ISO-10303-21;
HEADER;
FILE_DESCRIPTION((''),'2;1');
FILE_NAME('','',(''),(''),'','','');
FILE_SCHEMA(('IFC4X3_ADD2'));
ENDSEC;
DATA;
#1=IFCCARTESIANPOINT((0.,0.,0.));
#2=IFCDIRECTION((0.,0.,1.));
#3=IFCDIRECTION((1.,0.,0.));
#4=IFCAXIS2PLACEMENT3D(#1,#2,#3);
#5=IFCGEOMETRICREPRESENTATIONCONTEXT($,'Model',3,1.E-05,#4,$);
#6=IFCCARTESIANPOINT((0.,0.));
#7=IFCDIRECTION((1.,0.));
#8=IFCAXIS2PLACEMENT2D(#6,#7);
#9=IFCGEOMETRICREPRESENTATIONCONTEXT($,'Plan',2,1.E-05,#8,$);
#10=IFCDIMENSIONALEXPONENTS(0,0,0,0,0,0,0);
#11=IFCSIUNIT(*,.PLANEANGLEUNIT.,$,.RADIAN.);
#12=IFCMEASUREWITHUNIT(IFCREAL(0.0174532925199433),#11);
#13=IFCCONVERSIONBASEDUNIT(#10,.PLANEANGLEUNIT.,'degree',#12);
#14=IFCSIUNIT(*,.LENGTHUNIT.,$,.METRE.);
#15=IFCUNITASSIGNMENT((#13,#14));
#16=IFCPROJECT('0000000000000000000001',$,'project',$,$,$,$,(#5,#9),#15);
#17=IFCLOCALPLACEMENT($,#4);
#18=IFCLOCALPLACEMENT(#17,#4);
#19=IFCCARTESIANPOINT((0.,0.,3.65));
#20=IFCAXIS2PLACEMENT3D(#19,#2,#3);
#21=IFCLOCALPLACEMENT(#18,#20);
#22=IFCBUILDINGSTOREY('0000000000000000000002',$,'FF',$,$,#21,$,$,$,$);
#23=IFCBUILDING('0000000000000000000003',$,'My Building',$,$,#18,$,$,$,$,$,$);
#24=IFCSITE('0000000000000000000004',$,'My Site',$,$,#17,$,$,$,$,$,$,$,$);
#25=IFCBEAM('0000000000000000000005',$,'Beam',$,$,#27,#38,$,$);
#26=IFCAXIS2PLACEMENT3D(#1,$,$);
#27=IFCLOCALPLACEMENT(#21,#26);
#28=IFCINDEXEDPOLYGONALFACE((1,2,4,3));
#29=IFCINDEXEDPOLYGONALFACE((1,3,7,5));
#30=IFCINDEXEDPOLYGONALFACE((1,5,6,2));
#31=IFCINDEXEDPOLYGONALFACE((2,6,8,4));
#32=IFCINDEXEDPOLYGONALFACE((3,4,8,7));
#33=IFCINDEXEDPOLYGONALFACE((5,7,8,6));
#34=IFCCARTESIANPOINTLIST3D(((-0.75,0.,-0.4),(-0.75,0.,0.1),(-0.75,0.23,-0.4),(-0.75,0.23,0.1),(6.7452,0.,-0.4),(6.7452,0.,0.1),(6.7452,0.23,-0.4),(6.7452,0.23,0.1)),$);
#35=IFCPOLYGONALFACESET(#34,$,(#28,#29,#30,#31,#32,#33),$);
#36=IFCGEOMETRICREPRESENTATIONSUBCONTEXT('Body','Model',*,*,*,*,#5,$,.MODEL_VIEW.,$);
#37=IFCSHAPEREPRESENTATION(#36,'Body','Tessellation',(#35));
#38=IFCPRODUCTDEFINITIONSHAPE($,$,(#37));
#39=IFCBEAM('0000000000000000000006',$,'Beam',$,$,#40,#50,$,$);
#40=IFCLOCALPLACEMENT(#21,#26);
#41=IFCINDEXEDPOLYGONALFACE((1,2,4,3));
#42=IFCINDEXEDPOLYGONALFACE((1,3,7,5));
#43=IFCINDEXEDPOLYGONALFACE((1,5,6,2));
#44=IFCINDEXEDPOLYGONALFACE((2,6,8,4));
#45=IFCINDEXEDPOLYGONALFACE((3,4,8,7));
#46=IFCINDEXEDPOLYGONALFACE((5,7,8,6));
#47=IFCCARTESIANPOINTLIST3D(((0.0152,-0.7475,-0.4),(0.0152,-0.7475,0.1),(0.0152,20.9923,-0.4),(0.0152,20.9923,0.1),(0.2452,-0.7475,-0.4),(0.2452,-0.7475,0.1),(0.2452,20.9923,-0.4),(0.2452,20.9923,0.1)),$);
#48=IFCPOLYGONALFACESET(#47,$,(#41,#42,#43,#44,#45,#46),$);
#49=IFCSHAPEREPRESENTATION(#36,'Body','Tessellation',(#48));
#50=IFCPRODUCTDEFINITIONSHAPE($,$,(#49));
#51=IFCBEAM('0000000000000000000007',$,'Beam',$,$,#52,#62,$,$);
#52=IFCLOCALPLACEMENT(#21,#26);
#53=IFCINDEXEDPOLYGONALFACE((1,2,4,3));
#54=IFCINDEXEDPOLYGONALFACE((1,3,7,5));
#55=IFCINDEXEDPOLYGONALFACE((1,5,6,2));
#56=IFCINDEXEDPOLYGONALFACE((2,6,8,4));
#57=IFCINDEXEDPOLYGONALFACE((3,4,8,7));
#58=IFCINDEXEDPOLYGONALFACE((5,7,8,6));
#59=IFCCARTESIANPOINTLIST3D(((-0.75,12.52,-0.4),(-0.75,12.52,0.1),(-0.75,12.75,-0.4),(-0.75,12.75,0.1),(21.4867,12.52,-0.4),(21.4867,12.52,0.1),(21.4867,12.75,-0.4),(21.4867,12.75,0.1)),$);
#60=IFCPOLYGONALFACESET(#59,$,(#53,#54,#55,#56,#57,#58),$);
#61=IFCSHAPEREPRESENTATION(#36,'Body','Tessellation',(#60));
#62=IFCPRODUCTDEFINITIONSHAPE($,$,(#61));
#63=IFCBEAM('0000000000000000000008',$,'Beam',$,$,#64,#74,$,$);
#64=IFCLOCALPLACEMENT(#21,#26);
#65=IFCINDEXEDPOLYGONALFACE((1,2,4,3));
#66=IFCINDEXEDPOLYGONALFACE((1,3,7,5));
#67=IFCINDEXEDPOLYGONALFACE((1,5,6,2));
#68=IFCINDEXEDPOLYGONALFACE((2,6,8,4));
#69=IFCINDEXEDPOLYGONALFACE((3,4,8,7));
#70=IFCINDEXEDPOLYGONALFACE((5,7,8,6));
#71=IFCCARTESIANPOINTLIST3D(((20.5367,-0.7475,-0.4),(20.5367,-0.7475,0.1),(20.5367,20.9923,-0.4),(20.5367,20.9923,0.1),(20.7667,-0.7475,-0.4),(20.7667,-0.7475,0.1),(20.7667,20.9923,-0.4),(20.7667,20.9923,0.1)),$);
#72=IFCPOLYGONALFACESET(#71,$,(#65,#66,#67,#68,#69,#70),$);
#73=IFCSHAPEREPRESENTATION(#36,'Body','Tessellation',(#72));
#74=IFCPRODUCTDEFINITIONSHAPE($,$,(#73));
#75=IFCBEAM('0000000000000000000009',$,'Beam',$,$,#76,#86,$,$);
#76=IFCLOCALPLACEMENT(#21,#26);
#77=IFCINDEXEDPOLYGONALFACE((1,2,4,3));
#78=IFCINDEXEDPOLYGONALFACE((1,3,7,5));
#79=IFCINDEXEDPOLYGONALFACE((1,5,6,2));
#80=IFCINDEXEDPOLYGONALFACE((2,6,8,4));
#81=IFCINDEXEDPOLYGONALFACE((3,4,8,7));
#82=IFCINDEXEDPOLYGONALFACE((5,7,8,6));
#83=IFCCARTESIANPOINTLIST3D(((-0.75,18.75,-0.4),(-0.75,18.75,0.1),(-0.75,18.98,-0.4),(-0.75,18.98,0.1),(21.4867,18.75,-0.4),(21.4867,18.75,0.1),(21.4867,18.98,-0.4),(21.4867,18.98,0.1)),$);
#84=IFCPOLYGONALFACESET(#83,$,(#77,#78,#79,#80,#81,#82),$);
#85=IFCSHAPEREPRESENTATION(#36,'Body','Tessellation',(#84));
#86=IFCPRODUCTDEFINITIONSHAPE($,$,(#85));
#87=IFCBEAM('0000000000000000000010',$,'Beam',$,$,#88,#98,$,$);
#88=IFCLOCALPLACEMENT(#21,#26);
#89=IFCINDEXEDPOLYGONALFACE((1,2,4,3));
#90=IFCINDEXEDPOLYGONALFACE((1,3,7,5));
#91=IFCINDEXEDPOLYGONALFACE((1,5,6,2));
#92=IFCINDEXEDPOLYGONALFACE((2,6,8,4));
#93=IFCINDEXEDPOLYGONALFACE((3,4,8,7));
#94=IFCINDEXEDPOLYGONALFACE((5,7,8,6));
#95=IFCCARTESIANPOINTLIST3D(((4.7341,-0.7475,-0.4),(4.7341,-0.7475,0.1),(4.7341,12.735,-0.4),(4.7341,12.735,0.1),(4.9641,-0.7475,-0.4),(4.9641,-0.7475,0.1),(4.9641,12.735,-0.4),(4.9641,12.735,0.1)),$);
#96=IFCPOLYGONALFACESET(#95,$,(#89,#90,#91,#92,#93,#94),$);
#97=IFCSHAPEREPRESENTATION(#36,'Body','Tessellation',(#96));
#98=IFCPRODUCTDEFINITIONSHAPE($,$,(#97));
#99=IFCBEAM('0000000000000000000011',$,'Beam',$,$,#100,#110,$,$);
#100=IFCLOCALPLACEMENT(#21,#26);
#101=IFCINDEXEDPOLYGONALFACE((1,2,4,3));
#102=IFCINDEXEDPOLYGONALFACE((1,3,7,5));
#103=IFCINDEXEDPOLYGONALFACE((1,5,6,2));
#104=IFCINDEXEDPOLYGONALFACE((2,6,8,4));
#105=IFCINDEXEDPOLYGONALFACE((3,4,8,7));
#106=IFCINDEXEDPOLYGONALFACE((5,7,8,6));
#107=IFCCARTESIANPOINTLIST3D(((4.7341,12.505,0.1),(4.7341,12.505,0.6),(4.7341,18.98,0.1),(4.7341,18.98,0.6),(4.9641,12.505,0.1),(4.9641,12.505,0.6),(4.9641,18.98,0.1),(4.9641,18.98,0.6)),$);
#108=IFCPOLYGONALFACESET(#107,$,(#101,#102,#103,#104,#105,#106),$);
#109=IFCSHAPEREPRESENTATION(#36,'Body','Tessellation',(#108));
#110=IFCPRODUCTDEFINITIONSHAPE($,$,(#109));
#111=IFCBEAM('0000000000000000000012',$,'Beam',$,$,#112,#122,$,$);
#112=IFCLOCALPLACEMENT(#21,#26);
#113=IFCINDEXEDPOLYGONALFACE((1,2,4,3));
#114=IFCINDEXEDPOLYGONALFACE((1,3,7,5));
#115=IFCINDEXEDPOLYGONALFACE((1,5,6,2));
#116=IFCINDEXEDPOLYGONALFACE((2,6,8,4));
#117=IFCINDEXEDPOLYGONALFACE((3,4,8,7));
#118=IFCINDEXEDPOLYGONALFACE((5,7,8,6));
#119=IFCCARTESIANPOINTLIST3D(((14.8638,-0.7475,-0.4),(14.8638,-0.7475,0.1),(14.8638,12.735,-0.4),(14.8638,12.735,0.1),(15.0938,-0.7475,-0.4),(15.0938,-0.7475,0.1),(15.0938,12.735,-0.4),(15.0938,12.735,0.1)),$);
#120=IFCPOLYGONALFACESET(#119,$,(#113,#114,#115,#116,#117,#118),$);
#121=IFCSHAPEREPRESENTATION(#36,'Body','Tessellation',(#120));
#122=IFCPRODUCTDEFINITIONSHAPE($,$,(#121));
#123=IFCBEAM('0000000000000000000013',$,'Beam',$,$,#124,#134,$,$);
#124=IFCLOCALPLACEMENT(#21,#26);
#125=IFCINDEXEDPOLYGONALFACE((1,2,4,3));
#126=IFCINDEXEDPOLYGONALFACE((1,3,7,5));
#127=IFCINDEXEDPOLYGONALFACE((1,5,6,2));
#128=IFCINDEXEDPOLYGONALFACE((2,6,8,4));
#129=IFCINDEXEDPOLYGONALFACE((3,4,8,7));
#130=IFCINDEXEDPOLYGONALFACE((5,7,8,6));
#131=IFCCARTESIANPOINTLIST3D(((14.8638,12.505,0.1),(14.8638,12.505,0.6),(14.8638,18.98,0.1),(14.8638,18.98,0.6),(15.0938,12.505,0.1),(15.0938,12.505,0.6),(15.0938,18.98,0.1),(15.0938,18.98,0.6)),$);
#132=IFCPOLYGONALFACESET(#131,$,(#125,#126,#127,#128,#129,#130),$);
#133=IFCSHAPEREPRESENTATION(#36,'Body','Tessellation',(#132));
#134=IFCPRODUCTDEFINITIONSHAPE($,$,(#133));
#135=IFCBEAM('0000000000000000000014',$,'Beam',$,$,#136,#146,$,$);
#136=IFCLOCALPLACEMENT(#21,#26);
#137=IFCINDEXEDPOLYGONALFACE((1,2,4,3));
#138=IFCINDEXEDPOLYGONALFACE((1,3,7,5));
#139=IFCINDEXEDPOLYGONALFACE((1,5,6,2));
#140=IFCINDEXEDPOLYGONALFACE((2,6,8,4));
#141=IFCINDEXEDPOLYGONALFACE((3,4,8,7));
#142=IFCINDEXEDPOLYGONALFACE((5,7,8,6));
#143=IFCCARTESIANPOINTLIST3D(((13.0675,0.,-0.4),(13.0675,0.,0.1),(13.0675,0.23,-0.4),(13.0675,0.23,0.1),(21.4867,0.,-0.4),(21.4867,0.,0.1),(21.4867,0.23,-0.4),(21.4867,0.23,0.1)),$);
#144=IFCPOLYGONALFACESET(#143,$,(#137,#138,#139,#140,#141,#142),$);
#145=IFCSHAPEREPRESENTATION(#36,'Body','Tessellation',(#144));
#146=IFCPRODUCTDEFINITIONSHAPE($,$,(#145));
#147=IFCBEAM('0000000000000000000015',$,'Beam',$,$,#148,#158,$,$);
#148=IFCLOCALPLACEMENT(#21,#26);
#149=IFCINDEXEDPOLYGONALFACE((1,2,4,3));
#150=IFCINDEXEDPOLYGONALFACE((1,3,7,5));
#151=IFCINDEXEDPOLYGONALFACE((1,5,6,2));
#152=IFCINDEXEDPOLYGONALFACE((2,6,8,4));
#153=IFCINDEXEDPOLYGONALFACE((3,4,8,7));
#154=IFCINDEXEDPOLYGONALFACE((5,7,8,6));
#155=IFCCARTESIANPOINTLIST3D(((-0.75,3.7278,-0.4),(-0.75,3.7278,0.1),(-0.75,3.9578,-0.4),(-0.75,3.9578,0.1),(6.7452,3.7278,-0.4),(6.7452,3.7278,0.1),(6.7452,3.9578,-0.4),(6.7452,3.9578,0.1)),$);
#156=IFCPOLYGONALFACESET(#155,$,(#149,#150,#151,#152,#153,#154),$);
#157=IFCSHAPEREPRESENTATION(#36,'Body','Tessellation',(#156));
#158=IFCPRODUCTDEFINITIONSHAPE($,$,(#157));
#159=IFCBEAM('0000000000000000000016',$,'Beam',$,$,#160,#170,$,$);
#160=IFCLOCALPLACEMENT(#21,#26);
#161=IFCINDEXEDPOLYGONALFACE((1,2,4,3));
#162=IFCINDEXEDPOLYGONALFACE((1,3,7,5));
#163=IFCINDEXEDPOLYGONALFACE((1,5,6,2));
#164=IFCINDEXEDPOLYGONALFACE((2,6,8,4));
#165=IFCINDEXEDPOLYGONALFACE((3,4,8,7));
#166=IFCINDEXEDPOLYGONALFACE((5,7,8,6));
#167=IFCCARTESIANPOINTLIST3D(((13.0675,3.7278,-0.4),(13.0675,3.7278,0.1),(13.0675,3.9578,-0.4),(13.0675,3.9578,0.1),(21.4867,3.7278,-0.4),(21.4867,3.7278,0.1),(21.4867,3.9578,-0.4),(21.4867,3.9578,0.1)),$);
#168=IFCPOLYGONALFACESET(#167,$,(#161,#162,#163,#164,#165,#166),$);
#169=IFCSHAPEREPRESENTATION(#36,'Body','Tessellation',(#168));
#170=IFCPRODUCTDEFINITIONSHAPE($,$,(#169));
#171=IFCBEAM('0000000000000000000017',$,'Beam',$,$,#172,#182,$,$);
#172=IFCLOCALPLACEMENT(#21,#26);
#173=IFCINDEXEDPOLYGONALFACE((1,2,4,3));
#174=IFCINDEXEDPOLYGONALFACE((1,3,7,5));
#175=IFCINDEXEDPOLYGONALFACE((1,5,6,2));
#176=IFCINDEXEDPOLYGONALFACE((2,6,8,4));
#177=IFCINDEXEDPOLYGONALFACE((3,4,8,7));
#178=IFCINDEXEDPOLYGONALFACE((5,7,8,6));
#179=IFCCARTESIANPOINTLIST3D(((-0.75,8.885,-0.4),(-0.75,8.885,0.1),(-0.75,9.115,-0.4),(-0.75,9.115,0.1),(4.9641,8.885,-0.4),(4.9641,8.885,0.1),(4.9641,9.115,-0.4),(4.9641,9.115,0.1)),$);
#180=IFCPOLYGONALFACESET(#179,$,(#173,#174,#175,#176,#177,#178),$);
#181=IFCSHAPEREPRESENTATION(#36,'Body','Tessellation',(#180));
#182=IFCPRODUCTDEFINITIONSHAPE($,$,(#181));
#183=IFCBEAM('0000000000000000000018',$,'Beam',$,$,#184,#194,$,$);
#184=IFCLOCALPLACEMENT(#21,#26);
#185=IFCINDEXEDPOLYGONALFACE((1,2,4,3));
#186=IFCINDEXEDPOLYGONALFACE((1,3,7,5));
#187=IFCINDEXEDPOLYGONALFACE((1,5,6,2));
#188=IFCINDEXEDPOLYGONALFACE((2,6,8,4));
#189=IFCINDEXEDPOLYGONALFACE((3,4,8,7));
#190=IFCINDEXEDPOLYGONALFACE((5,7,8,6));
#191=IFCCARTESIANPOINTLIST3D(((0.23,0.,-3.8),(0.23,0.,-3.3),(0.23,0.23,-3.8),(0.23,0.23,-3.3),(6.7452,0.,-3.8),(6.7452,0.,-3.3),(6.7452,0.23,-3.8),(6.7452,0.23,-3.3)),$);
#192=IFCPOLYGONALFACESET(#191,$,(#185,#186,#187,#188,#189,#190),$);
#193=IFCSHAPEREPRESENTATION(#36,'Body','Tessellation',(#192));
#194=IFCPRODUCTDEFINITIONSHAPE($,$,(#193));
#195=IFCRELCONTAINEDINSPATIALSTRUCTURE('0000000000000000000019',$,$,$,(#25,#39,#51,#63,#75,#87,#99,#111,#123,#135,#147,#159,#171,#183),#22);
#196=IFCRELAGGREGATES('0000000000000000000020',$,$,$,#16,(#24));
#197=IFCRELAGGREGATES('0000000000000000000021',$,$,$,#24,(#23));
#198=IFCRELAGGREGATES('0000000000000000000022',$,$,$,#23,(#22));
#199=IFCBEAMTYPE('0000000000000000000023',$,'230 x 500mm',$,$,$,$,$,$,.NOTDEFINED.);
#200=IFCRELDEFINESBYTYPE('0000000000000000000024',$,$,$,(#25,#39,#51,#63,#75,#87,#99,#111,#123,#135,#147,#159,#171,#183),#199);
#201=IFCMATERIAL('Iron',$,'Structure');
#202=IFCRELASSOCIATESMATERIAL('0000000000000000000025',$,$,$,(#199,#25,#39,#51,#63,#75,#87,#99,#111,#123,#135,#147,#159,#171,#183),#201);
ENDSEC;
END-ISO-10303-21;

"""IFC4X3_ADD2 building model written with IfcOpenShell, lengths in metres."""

from ifc_helpers import new_model, entity, si_unit, converted_unit, frame, origin_with_axes, origin_2d_with_axis, place, context, subcontext, project, spatial, rectangle, extrude, material, material_profile, profile_set, profile_usage, type_object, element, save


model = new_model("IFC4X3_ADD2")

# Units and contexts
model_context = context("Model", 3, precision=1e-05, world=origin_with_axes())
plan_context = context("Plan", 2, precision=1e-05, world=origin_2d_with_axis())
body_context = subcontext(model_context, "Body", "Model", "MODEL_VIEW")
ifc_project = project(units=[converted_unit("PLANEANGLEUNIT", "degree", entity("IfcReal", 0.0174532925199433), si_unit("PLANEANGLEUNIT", "RADIAN"), dimensions=[0, 0, 0, 0, 0, 0, 0]), si_unit("LENGTHUNIT", "METRE")], contexts=[model_context, plan_context])

# Site, building, storey
site_placement = place(None, origin_with_axes())
site = spatial("IfcSite", under=ifc_project, at=site_placement, Name="My Site")
building_placement = place(site_placement, origin_with_axes())
building = spatial("IfcBuilding", under=site, at=building_placement, Name="My Building")
storey_placement = place(building_placement, frame((0.0, 0.0, 3.65), z_axis=(0.0, 0.0, 1.0), x_axis=(1.0, 0.0, 0.0)))
storey = spatial("IfcBuildingStorey", under=building, at=storey_placement, Name="FF")

# Beams
ifc_material_1 = material(Name="Iron", Category="Structure")
ifc_material_profile_1 = material_profile(ifc_material_1, rectangle(XDim=0.23, YDim=0.5))
ifc_profile_set_1 = profile_set([ifc_material_profile_1])
ifc_profile_usage_1 = profile_usage(ifc_profile_set_1)
beam_type_1 = type_object("IfcBeamType", Name="230 x 500mm", PredefinedType="NOTDEFINED", material=ifc_profile_set_1)
beam_1_placement = place(storey_placement, frame((-0.75, 0.115, -0.15), z_axis=(1.0, 0.0, 0.0), x_axis=(0.0, 1.0, 0.0)))
element("IfcBeam", 1, at=beam_1_placement, inside=storey, type_object=beam_type_1, material=ifc_profile_usage_1, Name="Beam", context=body_context, shape_type="SweptSolid", body=[
    extrude(rectangle(XDim=0.23, YDim=0.5), origin_with_axes(), (0.0, 0.0, 1.0), 7.4952),
])
ifc_profile_usage_2 = profile_usage(ifc_profile_set_1)
beam_2_placement = place(storey_placement, frame((0.1302, 20.9923, -0.15), z_axis=(0.0, -1.0, 0.0), x_axis=(1.0, 0.0, 0.0)))
element("IfcBeam", 2, at=beam_2_placement, inside=storey, type_object=beam_type_1, material=ifc_profile_usage_2, Name="Beam", context=body_context, shape_type="SweptSolid", body=[
    extrude(rectangle(XDim=0.23, YDim=0.5), origin_with_axes(), (0.0, 0.0, 1.0), 21.7398),
])
ifc_profile_usage_3 = profile_usage(ifc_profile_set_1)
beam_3_placement = place(storey_placement, frame((-0.75, 12.635, -0.15), z_axis=(1.0, -0.000002, 0.000001), x_axis=(0.000002, 1.0, 0.0)))
element("IfcBeam", 3, at=beam_3_placement, inside=storey, type_object=beam_type_1, material=ifc_profile_usage_3, Name="Beam", context=body_context, shape_type="SweptSolid", body=[
    extrude(rectangle(XDim=0.23, YDim=0.5), origin_with_axes(), (0.0, 0.0, 1.0), 22.2367),
])
ifc_profile_usage_4 = profile_usage(ifc_profile_set_1)
beam_4_placement = place(storey_placement, frame((20.6517, 20.9923, -0.15), z_axis=(0.0, -1.0, 0.0), x_axis=(1.0, 0.0, 0.0)))
element("IfcBeam", 4, at=beam_4_placement, inside=storey, type_object=beam_type_1, material=ifc_profile_usage_4, Name="Beam", context=body_context, shape_type="SweptSolid", body=[
    extrude(rectangle(XDim=0.23, YDim=0.5), origin_with_axes(), (0.0, 0.0, 1.0), 21.7398),
])
ifc_profile_usage_5 = profile_usage(ifc_profile_set_1)
beam_5_placement = place(storey_placement, frame((-0.75, 18.865, -0.15), z_axis=(1.0, 0.0, 0.0), x_axis=(0.0, 1.0, 0.0)))
element("IfcBeam", 5, at=beam_5_placement, inside=storey, type_object=beam_type_1, material=ifc_profile_usage_5, Name="Beam", context=body_context, shape_type="SweptSolid", body=[
    extrude(rectangle(XDim=0.23, YDim=0.5), origin_with_axes(), (0.0, 0.0, 1.0), 22.2367),
])
ifc_profile_usage_6 = profile_usage(ifc_profile_set_1)
beam_6_placement = place(storey_placement, frame((4.8491, 12.735, -0.15), z_axis=(0.0, -1.0, 0.0), x_axis=(1.0, 0.0, 0.0)))
element("IfcBeam", 6, at=beam_6_placement, inside=storey, type_object=beam_type_1, material=ifc_profile_usage_6, Name="Beam", context=body_context, shape_type="SweptSolid", body=[
    extrude(rectangle(XDim=0.23, YDim=0.5), origin_with_axes(), (0.0, 0.0, 1.0), 13.4825),
])
ifc_profile_usage_7 = profile_usage(ifc_profile_set_1)
beam_7_placement = place(storey_placement, frame((4.8491, 18.98, 0.35), z_axis=(0.0, -1.0, 0.0), x_axis=(1.0, 0.0, 0.0)))
element("IfcBeam", 7, at=beam_7_placement, inside=storey, type_object=beam_type_1, material=ifc_profile_usage_7, Name="Beam", context=body_context, shape_type="SweptSolid", body=[
    extrude(rectangle(XDim=0.23, YDim=0.5), origin_with_axes(), (0.0, 0.0, 1.0), 6.475),
])
ifc_profile_usage_8 = profile_usage(ifc_profile_set_1)
beam_8_placement = place(storey_placement, frame((14.9788, 12.735, -0.15), z_axis=(0.0, -1.0, 0.0), x_axis=(1.0, 0.0, 0.0)))
element("IfcBeam", 8, at=beam_8_placement, inside=storey, type_object=beam_type_1, material=ifc_profile_usage_8, Name="Beam", context=body_context, shape_type="SweptSolid", body=[
    extrude(rectangle(XDim=0.23, YDim=0.5), origin_with_axes(), (0.0, 0.0, 1.0), 13.4825),
])
ifc_profile_usage_9 = profile_usage(ifc_profile_set_1)
beam_9_placement = place(storey_placement, frame((14.9788, 18.98, 0.35), z_axis=(0.0, -1.0, 0.0), x_axis=(1.0, 0.0, 0.0)))
element("IfcBeam", 9, at=beam_9_placement, inside=storey, type_object=beam_type_1, material=ifc_profile_usage_9, Name="Beam", context=body_context, shape_type="SweptSolid", body=[
    extrude(rectangle(XDim=0.23, YDim=0.5), origin_with_axes(), (0.0, 0.0, 1.0), 6.475),
])
ifc_profile_usage_10 = profile_usage(ifc_profile_set_1)
beam_10_placement = place(storey_placement, frame((13.0675, 0.115, -0.15), z_axis=(1.0, 0.0, 0.0), x_axis=(0.0, 1.0, 0.0)))
element("IfcBeam", 10, at=beam_10_placement, inside=storey, type_object=beam_type_1, material=ifc_profile_usage_10, Name="Beam", context=body_context, shape_type="SweptSolid", body=[
    extrude(rectangle(XDim=0.23, YDim=0.5), origin_with_axes(), (0.0, 0.0, 1.0), 8.4193),
])
ifc_profile_usage_11 = profile_usage(ifc_profile_set_1)
beam_11_placement = place(storey_placement, frame((-0.75, 3.8428, -0.15), z_axis=(1.0, 0.0, 0.0), x_axis=(0.0, 1.0, 0.0)))
element("IfcBeam", 11, at=beam_11_placement, inside=storey, type_object=beam_type_1, material=ifc_profile_usage_11, Name="Beam", context=body_context, shape_type="SweptSolid", body=[
    extrude(rectangle(XDim=0.23, YDim=0.5), origin_with_axes(), (0.0, 0.0, 1.0), 7.4952),
])
ifc_profile_usage_12 = profile_usage(ifc_profile_set_1)
beam_12_placement = place(storey_placement, frame((13.0675, 3.8428, -0.15), z_axis=(1.0, 0.0, 0.0), x_axis=(0.0, 1.0, 0.0)))
element("IfcBeam", 12, at=beam_12_placement, inside=storey, type_object=beam_type_1, material=ifc_profile_usage_12, Name="Beam", context=body_context, shape_type="SweptSolid", body=[
    extrude(rectangle(XDim=0.23, YDim=0.5), origin_with_axes(), (0.0, 0.0, 1.0), 8.4193),
])
ifc_profile_usage_13 = profile_usage(ifc_profile_set_1)
beam_13_placement = place(storey_placement, frame((-0.75, 9.0, -0.15), z_axis=(1.0, 0.0, 0.0), x_axis=(0.0, 1.0, 0.0)))
element("IfcBeam", 13, at=beam_13_placement, inside=storey, type_object=beam_type_1, material=ifc_profile_usage_13, Name="Beam", context=body_context, shape_type="SweptSolid", body=[
    extrude(rectangle(XDim=0.23, YDim=0.5), origin_with_axes(), (0.0, 0.0, 1.0), 5.7141),
])
ifc_profile_usage_14 = profile_usage(ifc_profile_set_1)
beam_14_placement = place(storey_placement, frame((0.23, 0.115, -3.55), z_axis=(1.0, 0.0, 0.0), x_axis=(0.0, 1.0, 0.0)))
element("IfcBeam", 14, at=beam_14_placement, inside=storey, type_object=beam_type_1, material=ifc_profile_usage_14, Name="Beam", context=body_context, shape_type="SweptSolid", body=[
    extrude(rectangle(XDim=0.23, YDim=0.5), origin_with_axes(), (0.0, 0.0, 1.0), 6.5152),
])

save(model, "model.ifc")
